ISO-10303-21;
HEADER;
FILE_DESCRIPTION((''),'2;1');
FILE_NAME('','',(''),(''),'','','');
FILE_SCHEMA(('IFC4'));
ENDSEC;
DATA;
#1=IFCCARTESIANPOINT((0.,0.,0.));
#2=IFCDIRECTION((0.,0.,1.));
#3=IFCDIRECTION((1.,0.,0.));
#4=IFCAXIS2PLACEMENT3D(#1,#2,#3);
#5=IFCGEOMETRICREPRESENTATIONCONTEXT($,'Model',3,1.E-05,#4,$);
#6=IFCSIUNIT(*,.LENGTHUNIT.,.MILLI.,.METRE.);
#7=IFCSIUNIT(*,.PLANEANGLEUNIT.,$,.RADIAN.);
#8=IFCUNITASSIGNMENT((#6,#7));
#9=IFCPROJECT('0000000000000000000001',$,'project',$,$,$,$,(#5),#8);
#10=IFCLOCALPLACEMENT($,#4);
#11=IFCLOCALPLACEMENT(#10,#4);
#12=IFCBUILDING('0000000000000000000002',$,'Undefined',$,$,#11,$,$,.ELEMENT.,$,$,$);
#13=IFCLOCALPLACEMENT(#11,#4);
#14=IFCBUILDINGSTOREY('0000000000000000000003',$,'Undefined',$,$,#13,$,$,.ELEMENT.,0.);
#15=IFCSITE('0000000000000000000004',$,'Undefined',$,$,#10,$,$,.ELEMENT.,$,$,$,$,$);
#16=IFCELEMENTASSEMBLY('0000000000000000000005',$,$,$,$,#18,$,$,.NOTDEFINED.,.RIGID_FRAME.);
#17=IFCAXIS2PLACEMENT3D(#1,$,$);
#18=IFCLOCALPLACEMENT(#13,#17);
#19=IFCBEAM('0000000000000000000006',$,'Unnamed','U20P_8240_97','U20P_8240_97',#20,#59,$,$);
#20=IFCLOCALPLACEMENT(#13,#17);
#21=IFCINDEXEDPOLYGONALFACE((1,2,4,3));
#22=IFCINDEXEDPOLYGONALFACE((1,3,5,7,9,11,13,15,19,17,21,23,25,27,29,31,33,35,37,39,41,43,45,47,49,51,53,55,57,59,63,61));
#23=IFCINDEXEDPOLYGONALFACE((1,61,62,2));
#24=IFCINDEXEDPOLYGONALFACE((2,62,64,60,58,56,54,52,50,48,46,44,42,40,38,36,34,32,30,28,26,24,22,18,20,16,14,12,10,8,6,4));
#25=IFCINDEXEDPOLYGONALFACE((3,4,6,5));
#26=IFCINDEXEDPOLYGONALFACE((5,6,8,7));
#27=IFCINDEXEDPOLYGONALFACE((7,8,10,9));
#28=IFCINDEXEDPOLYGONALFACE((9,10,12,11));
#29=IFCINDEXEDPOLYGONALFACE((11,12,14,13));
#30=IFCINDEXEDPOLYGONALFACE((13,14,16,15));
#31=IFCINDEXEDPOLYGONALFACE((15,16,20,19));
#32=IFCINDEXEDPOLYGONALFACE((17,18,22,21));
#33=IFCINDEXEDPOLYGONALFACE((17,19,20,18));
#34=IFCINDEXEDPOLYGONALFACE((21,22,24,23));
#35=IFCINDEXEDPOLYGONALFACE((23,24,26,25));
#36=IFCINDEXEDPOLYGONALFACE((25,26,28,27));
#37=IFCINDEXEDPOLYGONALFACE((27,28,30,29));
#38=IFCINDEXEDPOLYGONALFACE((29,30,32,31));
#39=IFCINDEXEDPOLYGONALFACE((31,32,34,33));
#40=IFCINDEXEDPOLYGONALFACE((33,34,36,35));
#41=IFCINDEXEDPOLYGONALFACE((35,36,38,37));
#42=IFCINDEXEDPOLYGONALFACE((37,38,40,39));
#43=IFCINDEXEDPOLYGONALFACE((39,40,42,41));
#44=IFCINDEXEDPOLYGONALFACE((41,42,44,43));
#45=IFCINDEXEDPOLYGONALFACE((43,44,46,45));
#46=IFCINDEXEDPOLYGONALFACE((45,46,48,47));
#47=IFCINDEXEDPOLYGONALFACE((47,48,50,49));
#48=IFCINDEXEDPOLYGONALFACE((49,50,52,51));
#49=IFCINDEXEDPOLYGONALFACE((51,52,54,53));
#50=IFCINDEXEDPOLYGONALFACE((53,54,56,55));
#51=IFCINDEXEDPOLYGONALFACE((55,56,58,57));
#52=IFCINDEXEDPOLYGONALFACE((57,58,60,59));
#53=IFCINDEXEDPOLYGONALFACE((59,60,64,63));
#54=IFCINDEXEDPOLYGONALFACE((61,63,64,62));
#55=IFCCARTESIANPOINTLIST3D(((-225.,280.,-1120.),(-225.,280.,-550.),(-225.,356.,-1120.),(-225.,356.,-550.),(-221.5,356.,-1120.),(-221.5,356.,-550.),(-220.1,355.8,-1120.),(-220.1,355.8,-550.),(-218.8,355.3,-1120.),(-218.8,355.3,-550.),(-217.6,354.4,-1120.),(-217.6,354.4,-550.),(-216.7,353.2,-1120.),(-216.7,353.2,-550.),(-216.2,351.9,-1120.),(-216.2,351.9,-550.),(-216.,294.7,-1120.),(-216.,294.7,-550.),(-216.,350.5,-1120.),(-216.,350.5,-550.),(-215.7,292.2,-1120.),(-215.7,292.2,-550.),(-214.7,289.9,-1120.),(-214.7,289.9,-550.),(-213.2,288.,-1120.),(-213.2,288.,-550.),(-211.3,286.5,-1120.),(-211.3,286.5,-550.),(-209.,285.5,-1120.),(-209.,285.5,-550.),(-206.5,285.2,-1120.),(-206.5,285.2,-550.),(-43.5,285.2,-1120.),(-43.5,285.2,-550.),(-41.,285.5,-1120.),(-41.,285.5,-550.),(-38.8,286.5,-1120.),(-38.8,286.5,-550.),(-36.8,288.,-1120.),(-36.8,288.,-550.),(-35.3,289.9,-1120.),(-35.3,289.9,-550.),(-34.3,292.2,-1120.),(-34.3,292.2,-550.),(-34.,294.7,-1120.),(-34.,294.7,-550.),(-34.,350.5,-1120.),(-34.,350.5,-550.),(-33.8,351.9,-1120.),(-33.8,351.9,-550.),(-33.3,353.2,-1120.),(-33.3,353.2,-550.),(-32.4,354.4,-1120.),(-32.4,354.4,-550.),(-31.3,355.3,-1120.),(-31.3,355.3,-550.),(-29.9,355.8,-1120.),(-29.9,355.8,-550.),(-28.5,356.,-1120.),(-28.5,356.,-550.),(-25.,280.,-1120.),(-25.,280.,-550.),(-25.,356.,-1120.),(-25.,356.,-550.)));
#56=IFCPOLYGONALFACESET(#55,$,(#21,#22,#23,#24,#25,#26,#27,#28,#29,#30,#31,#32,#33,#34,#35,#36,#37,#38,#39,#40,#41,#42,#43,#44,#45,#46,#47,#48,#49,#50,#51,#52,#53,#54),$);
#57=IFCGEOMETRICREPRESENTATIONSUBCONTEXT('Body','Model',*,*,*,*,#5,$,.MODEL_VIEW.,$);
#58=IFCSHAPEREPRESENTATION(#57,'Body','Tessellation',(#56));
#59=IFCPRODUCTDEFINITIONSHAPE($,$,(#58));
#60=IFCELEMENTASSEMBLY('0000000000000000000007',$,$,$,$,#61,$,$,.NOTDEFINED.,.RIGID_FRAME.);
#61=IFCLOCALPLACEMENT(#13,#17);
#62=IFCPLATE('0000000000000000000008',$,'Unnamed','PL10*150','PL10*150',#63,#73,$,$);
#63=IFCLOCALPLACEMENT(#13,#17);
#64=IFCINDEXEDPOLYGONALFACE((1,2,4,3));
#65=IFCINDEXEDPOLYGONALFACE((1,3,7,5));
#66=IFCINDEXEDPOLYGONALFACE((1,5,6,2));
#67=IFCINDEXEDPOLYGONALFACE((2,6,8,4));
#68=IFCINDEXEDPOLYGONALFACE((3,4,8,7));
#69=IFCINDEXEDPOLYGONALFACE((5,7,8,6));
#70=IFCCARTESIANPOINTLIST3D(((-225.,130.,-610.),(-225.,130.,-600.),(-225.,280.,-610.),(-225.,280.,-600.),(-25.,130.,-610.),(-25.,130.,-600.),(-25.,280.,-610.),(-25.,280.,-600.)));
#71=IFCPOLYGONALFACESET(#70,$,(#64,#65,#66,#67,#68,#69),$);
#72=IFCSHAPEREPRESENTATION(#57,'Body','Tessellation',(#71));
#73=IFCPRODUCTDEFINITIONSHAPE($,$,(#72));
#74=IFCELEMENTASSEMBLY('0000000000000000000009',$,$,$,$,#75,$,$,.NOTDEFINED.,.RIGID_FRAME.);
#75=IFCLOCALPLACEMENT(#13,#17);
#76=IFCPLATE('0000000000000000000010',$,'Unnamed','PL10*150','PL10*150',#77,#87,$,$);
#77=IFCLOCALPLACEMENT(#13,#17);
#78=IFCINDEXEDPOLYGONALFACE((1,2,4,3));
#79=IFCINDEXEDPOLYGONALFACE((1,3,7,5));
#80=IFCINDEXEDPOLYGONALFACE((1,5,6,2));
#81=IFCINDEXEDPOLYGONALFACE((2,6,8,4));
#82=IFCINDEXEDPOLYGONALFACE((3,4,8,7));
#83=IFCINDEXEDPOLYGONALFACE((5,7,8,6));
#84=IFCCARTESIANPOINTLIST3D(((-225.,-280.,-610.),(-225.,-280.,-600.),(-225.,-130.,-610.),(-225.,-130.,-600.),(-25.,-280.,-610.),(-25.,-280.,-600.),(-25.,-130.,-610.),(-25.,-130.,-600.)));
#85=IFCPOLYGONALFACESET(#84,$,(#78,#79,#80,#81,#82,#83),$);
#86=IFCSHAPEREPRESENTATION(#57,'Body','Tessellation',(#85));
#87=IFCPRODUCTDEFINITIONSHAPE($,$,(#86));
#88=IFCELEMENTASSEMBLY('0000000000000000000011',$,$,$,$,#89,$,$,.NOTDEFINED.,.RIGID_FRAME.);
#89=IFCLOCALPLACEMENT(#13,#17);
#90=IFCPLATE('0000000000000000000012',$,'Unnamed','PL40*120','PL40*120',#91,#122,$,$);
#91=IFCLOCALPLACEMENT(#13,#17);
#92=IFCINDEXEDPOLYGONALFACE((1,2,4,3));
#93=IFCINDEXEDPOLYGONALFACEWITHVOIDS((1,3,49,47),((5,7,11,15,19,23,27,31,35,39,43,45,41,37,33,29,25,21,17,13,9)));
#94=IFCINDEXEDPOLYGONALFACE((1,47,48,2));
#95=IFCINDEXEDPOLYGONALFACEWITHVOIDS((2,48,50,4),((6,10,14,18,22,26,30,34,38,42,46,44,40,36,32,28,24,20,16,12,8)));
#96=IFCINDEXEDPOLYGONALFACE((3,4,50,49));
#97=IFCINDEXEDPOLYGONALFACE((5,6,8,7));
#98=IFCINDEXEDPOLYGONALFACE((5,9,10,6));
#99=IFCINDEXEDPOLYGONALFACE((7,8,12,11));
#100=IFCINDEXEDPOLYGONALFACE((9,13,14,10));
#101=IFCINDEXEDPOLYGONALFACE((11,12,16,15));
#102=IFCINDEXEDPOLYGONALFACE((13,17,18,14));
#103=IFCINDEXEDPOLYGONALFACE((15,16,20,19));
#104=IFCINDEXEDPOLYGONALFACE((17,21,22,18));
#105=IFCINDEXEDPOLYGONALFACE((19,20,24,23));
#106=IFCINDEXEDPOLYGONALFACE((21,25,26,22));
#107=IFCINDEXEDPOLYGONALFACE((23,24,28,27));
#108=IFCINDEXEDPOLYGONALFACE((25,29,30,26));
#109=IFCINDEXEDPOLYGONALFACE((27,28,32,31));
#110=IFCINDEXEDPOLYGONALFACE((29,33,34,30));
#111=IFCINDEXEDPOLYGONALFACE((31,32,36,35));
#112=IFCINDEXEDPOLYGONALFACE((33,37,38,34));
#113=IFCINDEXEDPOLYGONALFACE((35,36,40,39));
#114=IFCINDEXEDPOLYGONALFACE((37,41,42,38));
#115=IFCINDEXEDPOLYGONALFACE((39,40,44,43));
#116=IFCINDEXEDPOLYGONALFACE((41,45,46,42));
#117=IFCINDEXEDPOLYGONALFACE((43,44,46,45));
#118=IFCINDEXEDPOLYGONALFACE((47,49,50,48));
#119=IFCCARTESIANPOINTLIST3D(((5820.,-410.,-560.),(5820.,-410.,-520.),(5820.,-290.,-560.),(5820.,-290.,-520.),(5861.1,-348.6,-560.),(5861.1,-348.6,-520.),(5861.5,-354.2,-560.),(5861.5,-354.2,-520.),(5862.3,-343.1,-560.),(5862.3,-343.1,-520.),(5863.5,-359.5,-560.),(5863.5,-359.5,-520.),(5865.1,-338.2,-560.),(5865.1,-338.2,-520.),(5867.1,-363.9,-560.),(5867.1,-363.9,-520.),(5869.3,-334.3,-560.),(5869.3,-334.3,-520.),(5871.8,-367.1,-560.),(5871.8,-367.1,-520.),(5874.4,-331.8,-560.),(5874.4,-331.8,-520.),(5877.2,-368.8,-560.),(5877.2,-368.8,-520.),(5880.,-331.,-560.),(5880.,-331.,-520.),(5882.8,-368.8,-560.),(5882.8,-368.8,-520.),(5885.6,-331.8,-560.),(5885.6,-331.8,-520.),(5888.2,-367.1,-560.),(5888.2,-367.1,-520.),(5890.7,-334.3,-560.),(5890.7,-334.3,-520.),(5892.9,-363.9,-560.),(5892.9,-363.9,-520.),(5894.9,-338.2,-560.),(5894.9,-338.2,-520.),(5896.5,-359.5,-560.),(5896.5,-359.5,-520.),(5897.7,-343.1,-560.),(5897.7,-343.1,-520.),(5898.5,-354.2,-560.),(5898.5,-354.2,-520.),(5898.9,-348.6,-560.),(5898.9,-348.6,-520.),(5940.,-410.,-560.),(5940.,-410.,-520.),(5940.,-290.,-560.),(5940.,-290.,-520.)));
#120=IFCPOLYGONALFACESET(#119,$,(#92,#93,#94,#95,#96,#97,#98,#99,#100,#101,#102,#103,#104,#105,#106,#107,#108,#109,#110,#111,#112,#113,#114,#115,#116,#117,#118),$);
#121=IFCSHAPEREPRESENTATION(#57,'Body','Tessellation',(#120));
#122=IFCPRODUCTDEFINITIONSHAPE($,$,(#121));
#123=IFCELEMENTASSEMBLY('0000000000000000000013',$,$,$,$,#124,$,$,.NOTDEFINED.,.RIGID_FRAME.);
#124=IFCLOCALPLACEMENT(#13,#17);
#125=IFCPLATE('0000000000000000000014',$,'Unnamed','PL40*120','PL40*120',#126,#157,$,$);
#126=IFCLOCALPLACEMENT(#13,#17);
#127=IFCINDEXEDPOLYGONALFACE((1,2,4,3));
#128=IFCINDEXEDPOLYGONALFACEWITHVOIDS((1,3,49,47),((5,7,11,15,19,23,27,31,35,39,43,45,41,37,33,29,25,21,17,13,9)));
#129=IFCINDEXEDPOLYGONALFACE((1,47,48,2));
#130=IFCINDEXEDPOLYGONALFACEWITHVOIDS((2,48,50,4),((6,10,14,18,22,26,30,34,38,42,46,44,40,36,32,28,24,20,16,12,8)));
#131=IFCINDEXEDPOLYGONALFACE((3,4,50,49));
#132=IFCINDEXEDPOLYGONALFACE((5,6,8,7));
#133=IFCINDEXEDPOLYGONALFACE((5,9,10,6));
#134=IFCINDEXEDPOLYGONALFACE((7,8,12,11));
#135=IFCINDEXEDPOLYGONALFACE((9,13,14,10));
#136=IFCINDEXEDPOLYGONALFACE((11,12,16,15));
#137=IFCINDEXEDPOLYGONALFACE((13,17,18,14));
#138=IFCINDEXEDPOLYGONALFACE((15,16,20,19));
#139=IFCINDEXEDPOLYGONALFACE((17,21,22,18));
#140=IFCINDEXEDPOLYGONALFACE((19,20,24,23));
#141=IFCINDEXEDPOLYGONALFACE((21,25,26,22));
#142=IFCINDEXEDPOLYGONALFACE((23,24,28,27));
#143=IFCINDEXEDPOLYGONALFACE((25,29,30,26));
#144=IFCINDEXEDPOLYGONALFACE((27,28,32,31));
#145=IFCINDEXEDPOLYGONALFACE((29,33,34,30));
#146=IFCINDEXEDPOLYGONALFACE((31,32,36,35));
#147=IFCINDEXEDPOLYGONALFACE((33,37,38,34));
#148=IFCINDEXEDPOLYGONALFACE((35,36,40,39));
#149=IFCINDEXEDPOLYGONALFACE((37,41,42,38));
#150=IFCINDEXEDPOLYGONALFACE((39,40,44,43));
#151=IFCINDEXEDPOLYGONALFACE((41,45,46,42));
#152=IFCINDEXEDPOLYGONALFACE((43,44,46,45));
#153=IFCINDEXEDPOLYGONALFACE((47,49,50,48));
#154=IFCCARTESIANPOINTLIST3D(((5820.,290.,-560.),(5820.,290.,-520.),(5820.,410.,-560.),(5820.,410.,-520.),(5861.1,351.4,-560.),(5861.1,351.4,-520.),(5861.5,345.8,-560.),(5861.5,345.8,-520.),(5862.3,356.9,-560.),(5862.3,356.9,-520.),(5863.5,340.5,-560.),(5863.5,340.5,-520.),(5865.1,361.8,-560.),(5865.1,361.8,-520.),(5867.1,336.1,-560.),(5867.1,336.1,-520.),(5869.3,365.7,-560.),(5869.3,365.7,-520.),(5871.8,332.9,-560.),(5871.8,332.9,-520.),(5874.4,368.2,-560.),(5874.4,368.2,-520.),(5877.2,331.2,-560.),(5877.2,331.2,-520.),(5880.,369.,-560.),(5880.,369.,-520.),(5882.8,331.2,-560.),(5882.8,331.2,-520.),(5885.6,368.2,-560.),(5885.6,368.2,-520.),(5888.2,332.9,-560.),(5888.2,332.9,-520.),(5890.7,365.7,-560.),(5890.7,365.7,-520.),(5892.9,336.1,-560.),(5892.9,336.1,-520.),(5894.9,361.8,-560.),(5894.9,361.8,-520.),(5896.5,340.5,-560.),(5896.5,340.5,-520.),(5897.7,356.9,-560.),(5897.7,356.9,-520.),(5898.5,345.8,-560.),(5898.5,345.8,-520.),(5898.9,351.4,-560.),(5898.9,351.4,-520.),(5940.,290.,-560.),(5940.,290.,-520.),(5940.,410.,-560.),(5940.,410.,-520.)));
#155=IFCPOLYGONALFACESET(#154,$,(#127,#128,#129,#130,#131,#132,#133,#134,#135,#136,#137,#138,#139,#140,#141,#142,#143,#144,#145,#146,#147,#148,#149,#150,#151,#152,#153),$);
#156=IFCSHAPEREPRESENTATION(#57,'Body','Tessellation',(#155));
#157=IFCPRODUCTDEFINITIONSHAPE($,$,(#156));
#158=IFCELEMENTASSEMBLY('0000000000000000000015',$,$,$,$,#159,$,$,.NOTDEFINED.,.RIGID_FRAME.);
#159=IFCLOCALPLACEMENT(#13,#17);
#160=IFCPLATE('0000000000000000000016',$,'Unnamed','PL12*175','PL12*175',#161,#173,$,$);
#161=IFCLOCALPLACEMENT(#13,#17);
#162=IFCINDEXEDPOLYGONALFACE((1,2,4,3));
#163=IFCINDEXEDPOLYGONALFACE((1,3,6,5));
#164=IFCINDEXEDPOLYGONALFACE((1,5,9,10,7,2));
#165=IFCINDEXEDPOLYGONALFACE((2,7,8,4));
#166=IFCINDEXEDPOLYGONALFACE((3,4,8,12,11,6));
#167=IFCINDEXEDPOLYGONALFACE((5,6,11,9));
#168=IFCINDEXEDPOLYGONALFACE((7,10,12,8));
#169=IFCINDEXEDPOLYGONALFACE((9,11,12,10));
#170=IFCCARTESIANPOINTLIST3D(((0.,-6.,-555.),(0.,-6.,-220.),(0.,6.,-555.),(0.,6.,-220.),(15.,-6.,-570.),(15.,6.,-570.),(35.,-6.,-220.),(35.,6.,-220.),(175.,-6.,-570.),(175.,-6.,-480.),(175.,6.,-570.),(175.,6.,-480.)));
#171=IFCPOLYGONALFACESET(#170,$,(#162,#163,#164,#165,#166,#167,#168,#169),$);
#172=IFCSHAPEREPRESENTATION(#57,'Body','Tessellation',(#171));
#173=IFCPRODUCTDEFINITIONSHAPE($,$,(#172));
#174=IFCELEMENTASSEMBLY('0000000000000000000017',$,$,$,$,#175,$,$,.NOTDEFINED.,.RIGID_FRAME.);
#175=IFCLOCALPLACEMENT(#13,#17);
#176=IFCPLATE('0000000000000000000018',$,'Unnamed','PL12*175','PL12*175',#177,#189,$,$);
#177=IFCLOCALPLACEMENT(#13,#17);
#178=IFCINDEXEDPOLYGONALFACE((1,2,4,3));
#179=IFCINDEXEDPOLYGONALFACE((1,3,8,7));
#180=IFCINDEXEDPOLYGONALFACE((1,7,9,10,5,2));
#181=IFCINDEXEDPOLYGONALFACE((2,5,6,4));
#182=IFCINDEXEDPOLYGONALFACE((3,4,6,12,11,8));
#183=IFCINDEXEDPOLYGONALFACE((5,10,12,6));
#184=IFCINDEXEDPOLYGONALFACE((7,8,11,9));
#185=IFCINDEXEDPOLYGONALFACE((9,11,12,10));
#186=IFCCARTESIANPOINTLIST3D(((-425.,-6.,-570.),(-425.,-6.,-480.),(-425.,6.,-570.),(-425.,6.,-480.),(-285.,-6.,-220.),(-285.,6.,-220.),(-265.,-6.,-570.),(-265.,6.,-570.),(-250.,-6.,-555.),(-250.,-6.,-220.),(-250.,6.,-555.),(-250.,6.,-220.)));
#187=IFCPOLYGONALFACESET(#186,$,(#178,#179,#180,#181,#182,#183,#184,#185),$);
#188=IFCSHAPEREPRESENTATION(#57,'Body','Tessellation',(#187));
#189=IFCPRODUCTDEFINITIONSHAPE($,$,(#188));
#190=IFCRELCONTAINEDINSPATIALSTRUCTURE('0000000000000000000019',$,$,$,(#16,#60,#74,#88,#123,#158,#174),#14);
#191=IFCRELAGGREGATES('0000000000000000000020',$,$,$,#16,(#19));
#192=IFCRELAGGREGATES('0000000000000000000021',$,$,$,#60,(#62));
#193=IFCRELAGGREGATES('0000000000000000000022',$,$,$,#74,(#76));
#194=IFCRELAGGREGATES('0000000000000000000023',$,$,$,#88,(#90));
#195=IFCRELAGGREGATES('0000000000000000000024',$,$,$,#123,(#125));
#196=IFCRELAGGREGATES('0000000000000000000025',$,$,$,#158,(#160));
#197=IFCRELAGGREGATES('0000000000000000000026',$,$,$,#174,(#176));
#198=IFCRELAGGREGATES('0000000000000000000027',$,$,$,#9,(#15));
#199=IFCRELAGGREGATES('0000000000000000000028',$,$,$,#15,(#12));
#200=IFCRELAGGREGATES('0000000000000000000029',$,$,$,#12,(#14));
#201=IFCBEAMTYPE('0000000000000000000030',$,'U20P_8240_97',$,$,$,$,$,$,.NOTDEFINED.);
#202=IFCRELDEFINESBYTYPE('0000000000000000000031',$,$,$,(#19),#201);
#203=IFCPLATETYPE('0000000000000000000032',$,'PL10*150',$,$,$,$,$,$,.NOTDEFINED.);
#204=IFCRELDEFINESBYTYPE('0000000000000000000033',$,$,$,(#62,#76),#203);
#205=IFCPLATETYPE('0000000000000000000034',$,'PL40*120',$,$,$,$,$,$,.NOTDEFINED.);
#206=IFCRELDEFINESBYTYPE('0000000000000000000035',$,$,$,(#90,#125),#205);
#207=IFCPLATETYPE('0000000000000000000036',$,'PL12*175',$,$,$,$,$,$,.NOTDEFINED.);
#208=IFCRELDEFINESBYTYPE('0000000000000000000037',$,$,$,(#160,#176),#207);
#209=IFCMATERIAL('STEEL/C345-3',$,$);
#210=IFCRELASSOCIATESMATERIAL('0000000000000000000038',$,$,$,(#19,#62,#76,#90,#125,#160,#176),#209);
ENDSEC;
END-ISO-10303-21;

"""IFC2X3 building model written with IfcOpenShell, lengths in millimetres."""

from ifc_helpers import new_model, si_unit, frame, origin_with_axes, origin_2d_with_axis, place, context, subcontext, project, spatial, polyline, circle, u_section, outline, extrude, boolean, material, type_object, element, aggregate, save


model = new_model("IFC2X3")

# Units and contexts
model_context = context("Model", 3, precision=1e-05, world=origin_with_axes())
body_context = subcontext(model_context, "Body", "Model", "MODEL_VIEW")
ifc_project = project(units=[si_unit("LENGTHUNIT", "METRE", prefix="MILLI"), si_unit("PLANEANGLEUNIT", "RADIAN")], contexts=[model_context])

# Site, building, storey
site_placement = place(None, origin_with_axes())
site = spatial("IfcSite", under=ifc_project, at=site_placement, Name="Undefined", CompositionType="ELEMENT")
building_placement = place(site_placement, origin_with_axes())
building = spatial("IfcBuilding", under=site, at=building_placement, Name="Undefined", CompositionType="ELEMENT")
storey_placement = place(building_placement, origin_with_axes())
storey = spatial("IfcBuildingStorey", under=building, at=storey_placement, Name="Undefined", CompositionType="ELEMENT", Elevation=0.0)

# Shared definitions
ifc_material_1 = material(Name="STEEL/C345-3")

# Element assembly, beam
assembly_1_placement = place(storey_placement, origin_with_axes())
assembly_1 = element("IfcElementAssembly", 1, at=assembly_1_placement, inside=storey, AssemblyPlace="NOTDEFINED", PredefinedType="RIGID_FRAME")
beam_type_1 = type_object("IfcBeamType", Name="U20P_8240_97", PredefinedType="NOTDEFINED")
beam_1_placement = place(assembly_1_placement, frame((-125.0, 318.0, -550.0), z_axis=(-1.0, 0.0, 0.0), x_axis=(0.0, 0.0, -1.0)))
beam_1 = element("IfcBeam", 2, at=beam_1_placement, type_object=beam_type_1, material=ifc_material_1, Name="Unnamed", Description="U20P_8240_97", ObjectType="U20P_8240_97", context=body_context, shape_type="SweptSolid", body=[
    extrude(u_section(Depth=200.0, FlangeWidth=76.0, WebThickness=5.2, FlangeThickness=9.0, FilletRadius=9.5, EdgeRadius=5.5, at=origin_2d_with_axis()), frame((570.0, 0.0, 0.0), z_axis=(-1.0, 0.0, 0.0), x_axis=(0.0, -1.0, 0.0)), (0.0, 0.0, 1.0), 570.0),
])
aggregate(assembly_1, [beam_1])

# Element assemblies, plates
assembly_2_placement = place(storey_placement, origin_with_axes())
assembly_2 = element("IfcElementAssembly", 3, at=assembly_2_placement, inside=storey, AssemblyPlace="NOTDEFINED", PredefinedType="RIGID_FRAME")
plate_type_1 = type_object("IfcPlateType", Name="PL10*150", PredefinedType="NOTDEFINED")
plate_1_placement = place(assembly_2_placement, frame((-25.0, 130.0, -605.0), z_axis=(0.0, 0.0, 1.0), x_axis=(0.0, 1.0, 0.0)))
plate_1 = element("IfcPlate", 4, at=plate_1_placement, type_object=plate_type_1, material=ifc_material_1, Name="Unnamed", Description="PL10*150", ObjectType="PL10*150", context=body_context, shape_type="SweptSolid", body=[
    extrude(outline(polyline([(0.0, 0.0), (150.0, 0.0), (150.0, 200.0), (0.0, 200.0), (0.0, 0.0)])), frame((0.0, 0.0, -5.0), z_axis=(0.0, 0.0, 1.0), x_axis=(1.0, 0.0, 0.0)), (0.0, 0.0, 1.0), 10.0),
])
aggregate(assembly_2, [plate_1])
assembly_3_placement = place(storey_placement, origin_with_axes())
assembly_3 = element("IfcElementAssembly", 5, at=assembly_3_placement, inside=storey, AssemblyPlace="NOTDEFINED", PredefinedType="RIGID_FRAME")
plate_2_placement = place(assembly_3_placement, frame((-25.0, -130.0, -605.0), z_axis=(0.0, 0.0, -1.0), x_axis=(0.0, -1.0, 0.0)))
plate_2 = element("IfcPlate", 6, at=plate_2_placement, type_object=plate_type_1, material=ifc_material_1, Name="Unnamed", Description="PL10*150", ObjectType="PL10*150", context=body_context, shape_type="SweptSolid", body=[
    extrude(outline(polyline([(0.0, 0.0), (150.0, 0.0), (150.0, 200.0), (0.0, 200.0), (0.0, 0.0)])), frame((0.0, 0.0, -5.0), z_axis=(0.0, 0.0, 1.0), x_axis=(1.0, 0.0, 0.0)), (0.0, 0.0, 1.0), 10.0),
])
aggregate(assembly_3, [plate_2])
assembly_4_placement = place(storey_placement, origin_with_axes())
assembly_4 = element("IfcElementAssembly", 7, at=assembly_4_placement, inside=storey, AssemblyPlace="NOTDEFINED", PredefinedType="RIGID_FRAME")
plate_type_2 = type_object("IfcPlateType", Name="PL40*120", PredefinedType="NOTDEFINED")
plate_3_placement = place(assembly_4_placement, frame((5820.0, -410.0, -540.0), z_axis=(0.0, 0.0, 1.0), x_axis=(1.0, 0.0, 0.0)))
plate_3 = element("IfcPlate", 8, at=plate_3_placement, type_object=plate_type_2, material=ifc_material_1, Name="Unnamed", Description="PL40*120", ObjectType="PL40*120", context=body_context, shape_type="CSG", body=[
    boolean("DIFFERENCE", extrude(outline(polyline([(0.0, 0.0), (120.0, 0.0), (120.0, 120.0), (0.0, 120.0), (0.0, 0.0)])), frame((0.0, 0.0, -20.0), z_axis=(0.0, 0.0, 1.0), x_axis=(1.0, 0.0, 0.0)), (0.0, 0.0, 1.0), 40.0), extrude(circle(Radius=19.0, at=origin_2d_with_axis()), frame((60.0, 60.0, 40.0), z_axis=(0.0, 0.0, -1.0), x_axis=(0.0, 1.0, 0.0)), (0.0, 0.0, 1.0), 80.0)),
])
aggregate(assembly_4, [plate_3])
assembly_5_placement = place(storey_placement, origin_with_axes())
assembly_5 = element("IfcElementAssembly", 9, at=assembly_5_placement, inside=storey, AssemblyPlace="NOTDEFINED", PredefinedType="RIGID_FRAME")
plate_4_placement = place(assembly_5_placement, frame((5820.0, 290.0, -540.0), z_axis=(0.0, 0.0, 1.0), x_axis=(1.0, 0.0, 0.0)))
plate_4 = element("IfcPlate", 10, at=plate_4_placement, type_object=plate_type_2, material=ifc_material_1, Name="Unnamed", Description="PL40*120", ObjectType="PL40*120", context=body_context, shape_type="CSG", body=[
    boolean("DIFFERENCE", extrude(outline(polyline([(0.0, 0.0), (120.0, 0.0), (120.0, 120.0), (0.0, 120.0), (0.0, 0.0)])), frame((0.0, 0.0, -20.0), z_axis=(0.0, 0.0, 1.0), x_axis=(1.0, 0.0, 0.0)), (0.0, 0.0, 1.0), 40.0), extrude(circle(Radius=19.0, at=origin_2d_with_axis()), frame((60.0, 60.0, 40.0), z_axis=(0.0, 0.0, -1.0), x_axis=(0.0, 1.0, 0.0)), (0.0, 0.0, 1.0), 80.0)),
])
aggregate(assembly_5, [plate_4])
assembly_6_placement = place(storey_placement, origin_with_axes())
assembly_6 = element("IfcElementAssembly", 11, at=assembly_6_placement, inside=storey, AssemblyPlace="NOTDEFINED", PredefinedType="RIGID_FRAME")
plate_type_3 = type_object("IfcPlateType", Name="PL12*175", PredefinedType="NOTDEFINED")
plate_5_placement = place(assembly_6_placement, frame((175.0, 0.0, -570.0), z_axis=(0.0, 1.0, 0.0), x_axis=(-1.0, 0.0, 0.0)))
plate_5 = element("IfcPlate", 12, at=plate_5_placement, type_object=plate_type_3, material=ifc_material_1, Name="Unnamed", Description="PL12*175", ObjectType="PL12*175", context=body_context, shape_type="SweptSolid", body=[
    extrude(outline(polyline([(0.0, 0.0), (160.0, 0.0), (175.0, 15.0), (175.0, 350.0), (140.0, 350.0), (0.0, 90.0), (0.0, 0.0)])), frame((0.0, 0.0, -6.0), z_axis=(0.0, 0.0, 1.0), x_axis=(1.0, 0.0, 0.0)), (0.0, 0.0, 1.0), 12.0),
])
aggregate(assembly_6, [plate_5])
assembly_7_placement = place(storey_placement, origin_with_axes())
assembly_7 = element("IfcElementAssembly", 13, at=assembly_7_placement, inside=storey, AssemblyPlace="NOTDEFINED", PredefinedType="RIGID_FRAME")
plate_6_placement = place(assembly_7_placement, frame((-425.0, 0.0, -570.0), z_axis=(0.0, -1.0, 0.0), x_axis=(1.0, 0.0, 0.0)))
plate_6 = element("IfcPlate", 14, at=plate_6_placement, type_object=plate_type_3, material=ifc_material_1, Name="Unnamed", Description="PL12*175", ObjectType="PL12*175", context=body_context, shape_type="SweptSolid", body=[
    extrude(outline(polyline([(0.0, 0.0), (160.0, 0.0), (175.0, 15.0), (175.0, 350.0), (140.0, 350.0), (0.0, 90.0), (0.0, 0.0)])), frame((0.0, 0.0, -6.0), z_axis=(0.0, 0.0, 1.0), x_axis=(1.0, 0.0, 0.0)), (0.0, 0.0, 1.0), 12.0),
])
aggregate(assembly_7, [plate_6])

save(model, "model.ifc")
